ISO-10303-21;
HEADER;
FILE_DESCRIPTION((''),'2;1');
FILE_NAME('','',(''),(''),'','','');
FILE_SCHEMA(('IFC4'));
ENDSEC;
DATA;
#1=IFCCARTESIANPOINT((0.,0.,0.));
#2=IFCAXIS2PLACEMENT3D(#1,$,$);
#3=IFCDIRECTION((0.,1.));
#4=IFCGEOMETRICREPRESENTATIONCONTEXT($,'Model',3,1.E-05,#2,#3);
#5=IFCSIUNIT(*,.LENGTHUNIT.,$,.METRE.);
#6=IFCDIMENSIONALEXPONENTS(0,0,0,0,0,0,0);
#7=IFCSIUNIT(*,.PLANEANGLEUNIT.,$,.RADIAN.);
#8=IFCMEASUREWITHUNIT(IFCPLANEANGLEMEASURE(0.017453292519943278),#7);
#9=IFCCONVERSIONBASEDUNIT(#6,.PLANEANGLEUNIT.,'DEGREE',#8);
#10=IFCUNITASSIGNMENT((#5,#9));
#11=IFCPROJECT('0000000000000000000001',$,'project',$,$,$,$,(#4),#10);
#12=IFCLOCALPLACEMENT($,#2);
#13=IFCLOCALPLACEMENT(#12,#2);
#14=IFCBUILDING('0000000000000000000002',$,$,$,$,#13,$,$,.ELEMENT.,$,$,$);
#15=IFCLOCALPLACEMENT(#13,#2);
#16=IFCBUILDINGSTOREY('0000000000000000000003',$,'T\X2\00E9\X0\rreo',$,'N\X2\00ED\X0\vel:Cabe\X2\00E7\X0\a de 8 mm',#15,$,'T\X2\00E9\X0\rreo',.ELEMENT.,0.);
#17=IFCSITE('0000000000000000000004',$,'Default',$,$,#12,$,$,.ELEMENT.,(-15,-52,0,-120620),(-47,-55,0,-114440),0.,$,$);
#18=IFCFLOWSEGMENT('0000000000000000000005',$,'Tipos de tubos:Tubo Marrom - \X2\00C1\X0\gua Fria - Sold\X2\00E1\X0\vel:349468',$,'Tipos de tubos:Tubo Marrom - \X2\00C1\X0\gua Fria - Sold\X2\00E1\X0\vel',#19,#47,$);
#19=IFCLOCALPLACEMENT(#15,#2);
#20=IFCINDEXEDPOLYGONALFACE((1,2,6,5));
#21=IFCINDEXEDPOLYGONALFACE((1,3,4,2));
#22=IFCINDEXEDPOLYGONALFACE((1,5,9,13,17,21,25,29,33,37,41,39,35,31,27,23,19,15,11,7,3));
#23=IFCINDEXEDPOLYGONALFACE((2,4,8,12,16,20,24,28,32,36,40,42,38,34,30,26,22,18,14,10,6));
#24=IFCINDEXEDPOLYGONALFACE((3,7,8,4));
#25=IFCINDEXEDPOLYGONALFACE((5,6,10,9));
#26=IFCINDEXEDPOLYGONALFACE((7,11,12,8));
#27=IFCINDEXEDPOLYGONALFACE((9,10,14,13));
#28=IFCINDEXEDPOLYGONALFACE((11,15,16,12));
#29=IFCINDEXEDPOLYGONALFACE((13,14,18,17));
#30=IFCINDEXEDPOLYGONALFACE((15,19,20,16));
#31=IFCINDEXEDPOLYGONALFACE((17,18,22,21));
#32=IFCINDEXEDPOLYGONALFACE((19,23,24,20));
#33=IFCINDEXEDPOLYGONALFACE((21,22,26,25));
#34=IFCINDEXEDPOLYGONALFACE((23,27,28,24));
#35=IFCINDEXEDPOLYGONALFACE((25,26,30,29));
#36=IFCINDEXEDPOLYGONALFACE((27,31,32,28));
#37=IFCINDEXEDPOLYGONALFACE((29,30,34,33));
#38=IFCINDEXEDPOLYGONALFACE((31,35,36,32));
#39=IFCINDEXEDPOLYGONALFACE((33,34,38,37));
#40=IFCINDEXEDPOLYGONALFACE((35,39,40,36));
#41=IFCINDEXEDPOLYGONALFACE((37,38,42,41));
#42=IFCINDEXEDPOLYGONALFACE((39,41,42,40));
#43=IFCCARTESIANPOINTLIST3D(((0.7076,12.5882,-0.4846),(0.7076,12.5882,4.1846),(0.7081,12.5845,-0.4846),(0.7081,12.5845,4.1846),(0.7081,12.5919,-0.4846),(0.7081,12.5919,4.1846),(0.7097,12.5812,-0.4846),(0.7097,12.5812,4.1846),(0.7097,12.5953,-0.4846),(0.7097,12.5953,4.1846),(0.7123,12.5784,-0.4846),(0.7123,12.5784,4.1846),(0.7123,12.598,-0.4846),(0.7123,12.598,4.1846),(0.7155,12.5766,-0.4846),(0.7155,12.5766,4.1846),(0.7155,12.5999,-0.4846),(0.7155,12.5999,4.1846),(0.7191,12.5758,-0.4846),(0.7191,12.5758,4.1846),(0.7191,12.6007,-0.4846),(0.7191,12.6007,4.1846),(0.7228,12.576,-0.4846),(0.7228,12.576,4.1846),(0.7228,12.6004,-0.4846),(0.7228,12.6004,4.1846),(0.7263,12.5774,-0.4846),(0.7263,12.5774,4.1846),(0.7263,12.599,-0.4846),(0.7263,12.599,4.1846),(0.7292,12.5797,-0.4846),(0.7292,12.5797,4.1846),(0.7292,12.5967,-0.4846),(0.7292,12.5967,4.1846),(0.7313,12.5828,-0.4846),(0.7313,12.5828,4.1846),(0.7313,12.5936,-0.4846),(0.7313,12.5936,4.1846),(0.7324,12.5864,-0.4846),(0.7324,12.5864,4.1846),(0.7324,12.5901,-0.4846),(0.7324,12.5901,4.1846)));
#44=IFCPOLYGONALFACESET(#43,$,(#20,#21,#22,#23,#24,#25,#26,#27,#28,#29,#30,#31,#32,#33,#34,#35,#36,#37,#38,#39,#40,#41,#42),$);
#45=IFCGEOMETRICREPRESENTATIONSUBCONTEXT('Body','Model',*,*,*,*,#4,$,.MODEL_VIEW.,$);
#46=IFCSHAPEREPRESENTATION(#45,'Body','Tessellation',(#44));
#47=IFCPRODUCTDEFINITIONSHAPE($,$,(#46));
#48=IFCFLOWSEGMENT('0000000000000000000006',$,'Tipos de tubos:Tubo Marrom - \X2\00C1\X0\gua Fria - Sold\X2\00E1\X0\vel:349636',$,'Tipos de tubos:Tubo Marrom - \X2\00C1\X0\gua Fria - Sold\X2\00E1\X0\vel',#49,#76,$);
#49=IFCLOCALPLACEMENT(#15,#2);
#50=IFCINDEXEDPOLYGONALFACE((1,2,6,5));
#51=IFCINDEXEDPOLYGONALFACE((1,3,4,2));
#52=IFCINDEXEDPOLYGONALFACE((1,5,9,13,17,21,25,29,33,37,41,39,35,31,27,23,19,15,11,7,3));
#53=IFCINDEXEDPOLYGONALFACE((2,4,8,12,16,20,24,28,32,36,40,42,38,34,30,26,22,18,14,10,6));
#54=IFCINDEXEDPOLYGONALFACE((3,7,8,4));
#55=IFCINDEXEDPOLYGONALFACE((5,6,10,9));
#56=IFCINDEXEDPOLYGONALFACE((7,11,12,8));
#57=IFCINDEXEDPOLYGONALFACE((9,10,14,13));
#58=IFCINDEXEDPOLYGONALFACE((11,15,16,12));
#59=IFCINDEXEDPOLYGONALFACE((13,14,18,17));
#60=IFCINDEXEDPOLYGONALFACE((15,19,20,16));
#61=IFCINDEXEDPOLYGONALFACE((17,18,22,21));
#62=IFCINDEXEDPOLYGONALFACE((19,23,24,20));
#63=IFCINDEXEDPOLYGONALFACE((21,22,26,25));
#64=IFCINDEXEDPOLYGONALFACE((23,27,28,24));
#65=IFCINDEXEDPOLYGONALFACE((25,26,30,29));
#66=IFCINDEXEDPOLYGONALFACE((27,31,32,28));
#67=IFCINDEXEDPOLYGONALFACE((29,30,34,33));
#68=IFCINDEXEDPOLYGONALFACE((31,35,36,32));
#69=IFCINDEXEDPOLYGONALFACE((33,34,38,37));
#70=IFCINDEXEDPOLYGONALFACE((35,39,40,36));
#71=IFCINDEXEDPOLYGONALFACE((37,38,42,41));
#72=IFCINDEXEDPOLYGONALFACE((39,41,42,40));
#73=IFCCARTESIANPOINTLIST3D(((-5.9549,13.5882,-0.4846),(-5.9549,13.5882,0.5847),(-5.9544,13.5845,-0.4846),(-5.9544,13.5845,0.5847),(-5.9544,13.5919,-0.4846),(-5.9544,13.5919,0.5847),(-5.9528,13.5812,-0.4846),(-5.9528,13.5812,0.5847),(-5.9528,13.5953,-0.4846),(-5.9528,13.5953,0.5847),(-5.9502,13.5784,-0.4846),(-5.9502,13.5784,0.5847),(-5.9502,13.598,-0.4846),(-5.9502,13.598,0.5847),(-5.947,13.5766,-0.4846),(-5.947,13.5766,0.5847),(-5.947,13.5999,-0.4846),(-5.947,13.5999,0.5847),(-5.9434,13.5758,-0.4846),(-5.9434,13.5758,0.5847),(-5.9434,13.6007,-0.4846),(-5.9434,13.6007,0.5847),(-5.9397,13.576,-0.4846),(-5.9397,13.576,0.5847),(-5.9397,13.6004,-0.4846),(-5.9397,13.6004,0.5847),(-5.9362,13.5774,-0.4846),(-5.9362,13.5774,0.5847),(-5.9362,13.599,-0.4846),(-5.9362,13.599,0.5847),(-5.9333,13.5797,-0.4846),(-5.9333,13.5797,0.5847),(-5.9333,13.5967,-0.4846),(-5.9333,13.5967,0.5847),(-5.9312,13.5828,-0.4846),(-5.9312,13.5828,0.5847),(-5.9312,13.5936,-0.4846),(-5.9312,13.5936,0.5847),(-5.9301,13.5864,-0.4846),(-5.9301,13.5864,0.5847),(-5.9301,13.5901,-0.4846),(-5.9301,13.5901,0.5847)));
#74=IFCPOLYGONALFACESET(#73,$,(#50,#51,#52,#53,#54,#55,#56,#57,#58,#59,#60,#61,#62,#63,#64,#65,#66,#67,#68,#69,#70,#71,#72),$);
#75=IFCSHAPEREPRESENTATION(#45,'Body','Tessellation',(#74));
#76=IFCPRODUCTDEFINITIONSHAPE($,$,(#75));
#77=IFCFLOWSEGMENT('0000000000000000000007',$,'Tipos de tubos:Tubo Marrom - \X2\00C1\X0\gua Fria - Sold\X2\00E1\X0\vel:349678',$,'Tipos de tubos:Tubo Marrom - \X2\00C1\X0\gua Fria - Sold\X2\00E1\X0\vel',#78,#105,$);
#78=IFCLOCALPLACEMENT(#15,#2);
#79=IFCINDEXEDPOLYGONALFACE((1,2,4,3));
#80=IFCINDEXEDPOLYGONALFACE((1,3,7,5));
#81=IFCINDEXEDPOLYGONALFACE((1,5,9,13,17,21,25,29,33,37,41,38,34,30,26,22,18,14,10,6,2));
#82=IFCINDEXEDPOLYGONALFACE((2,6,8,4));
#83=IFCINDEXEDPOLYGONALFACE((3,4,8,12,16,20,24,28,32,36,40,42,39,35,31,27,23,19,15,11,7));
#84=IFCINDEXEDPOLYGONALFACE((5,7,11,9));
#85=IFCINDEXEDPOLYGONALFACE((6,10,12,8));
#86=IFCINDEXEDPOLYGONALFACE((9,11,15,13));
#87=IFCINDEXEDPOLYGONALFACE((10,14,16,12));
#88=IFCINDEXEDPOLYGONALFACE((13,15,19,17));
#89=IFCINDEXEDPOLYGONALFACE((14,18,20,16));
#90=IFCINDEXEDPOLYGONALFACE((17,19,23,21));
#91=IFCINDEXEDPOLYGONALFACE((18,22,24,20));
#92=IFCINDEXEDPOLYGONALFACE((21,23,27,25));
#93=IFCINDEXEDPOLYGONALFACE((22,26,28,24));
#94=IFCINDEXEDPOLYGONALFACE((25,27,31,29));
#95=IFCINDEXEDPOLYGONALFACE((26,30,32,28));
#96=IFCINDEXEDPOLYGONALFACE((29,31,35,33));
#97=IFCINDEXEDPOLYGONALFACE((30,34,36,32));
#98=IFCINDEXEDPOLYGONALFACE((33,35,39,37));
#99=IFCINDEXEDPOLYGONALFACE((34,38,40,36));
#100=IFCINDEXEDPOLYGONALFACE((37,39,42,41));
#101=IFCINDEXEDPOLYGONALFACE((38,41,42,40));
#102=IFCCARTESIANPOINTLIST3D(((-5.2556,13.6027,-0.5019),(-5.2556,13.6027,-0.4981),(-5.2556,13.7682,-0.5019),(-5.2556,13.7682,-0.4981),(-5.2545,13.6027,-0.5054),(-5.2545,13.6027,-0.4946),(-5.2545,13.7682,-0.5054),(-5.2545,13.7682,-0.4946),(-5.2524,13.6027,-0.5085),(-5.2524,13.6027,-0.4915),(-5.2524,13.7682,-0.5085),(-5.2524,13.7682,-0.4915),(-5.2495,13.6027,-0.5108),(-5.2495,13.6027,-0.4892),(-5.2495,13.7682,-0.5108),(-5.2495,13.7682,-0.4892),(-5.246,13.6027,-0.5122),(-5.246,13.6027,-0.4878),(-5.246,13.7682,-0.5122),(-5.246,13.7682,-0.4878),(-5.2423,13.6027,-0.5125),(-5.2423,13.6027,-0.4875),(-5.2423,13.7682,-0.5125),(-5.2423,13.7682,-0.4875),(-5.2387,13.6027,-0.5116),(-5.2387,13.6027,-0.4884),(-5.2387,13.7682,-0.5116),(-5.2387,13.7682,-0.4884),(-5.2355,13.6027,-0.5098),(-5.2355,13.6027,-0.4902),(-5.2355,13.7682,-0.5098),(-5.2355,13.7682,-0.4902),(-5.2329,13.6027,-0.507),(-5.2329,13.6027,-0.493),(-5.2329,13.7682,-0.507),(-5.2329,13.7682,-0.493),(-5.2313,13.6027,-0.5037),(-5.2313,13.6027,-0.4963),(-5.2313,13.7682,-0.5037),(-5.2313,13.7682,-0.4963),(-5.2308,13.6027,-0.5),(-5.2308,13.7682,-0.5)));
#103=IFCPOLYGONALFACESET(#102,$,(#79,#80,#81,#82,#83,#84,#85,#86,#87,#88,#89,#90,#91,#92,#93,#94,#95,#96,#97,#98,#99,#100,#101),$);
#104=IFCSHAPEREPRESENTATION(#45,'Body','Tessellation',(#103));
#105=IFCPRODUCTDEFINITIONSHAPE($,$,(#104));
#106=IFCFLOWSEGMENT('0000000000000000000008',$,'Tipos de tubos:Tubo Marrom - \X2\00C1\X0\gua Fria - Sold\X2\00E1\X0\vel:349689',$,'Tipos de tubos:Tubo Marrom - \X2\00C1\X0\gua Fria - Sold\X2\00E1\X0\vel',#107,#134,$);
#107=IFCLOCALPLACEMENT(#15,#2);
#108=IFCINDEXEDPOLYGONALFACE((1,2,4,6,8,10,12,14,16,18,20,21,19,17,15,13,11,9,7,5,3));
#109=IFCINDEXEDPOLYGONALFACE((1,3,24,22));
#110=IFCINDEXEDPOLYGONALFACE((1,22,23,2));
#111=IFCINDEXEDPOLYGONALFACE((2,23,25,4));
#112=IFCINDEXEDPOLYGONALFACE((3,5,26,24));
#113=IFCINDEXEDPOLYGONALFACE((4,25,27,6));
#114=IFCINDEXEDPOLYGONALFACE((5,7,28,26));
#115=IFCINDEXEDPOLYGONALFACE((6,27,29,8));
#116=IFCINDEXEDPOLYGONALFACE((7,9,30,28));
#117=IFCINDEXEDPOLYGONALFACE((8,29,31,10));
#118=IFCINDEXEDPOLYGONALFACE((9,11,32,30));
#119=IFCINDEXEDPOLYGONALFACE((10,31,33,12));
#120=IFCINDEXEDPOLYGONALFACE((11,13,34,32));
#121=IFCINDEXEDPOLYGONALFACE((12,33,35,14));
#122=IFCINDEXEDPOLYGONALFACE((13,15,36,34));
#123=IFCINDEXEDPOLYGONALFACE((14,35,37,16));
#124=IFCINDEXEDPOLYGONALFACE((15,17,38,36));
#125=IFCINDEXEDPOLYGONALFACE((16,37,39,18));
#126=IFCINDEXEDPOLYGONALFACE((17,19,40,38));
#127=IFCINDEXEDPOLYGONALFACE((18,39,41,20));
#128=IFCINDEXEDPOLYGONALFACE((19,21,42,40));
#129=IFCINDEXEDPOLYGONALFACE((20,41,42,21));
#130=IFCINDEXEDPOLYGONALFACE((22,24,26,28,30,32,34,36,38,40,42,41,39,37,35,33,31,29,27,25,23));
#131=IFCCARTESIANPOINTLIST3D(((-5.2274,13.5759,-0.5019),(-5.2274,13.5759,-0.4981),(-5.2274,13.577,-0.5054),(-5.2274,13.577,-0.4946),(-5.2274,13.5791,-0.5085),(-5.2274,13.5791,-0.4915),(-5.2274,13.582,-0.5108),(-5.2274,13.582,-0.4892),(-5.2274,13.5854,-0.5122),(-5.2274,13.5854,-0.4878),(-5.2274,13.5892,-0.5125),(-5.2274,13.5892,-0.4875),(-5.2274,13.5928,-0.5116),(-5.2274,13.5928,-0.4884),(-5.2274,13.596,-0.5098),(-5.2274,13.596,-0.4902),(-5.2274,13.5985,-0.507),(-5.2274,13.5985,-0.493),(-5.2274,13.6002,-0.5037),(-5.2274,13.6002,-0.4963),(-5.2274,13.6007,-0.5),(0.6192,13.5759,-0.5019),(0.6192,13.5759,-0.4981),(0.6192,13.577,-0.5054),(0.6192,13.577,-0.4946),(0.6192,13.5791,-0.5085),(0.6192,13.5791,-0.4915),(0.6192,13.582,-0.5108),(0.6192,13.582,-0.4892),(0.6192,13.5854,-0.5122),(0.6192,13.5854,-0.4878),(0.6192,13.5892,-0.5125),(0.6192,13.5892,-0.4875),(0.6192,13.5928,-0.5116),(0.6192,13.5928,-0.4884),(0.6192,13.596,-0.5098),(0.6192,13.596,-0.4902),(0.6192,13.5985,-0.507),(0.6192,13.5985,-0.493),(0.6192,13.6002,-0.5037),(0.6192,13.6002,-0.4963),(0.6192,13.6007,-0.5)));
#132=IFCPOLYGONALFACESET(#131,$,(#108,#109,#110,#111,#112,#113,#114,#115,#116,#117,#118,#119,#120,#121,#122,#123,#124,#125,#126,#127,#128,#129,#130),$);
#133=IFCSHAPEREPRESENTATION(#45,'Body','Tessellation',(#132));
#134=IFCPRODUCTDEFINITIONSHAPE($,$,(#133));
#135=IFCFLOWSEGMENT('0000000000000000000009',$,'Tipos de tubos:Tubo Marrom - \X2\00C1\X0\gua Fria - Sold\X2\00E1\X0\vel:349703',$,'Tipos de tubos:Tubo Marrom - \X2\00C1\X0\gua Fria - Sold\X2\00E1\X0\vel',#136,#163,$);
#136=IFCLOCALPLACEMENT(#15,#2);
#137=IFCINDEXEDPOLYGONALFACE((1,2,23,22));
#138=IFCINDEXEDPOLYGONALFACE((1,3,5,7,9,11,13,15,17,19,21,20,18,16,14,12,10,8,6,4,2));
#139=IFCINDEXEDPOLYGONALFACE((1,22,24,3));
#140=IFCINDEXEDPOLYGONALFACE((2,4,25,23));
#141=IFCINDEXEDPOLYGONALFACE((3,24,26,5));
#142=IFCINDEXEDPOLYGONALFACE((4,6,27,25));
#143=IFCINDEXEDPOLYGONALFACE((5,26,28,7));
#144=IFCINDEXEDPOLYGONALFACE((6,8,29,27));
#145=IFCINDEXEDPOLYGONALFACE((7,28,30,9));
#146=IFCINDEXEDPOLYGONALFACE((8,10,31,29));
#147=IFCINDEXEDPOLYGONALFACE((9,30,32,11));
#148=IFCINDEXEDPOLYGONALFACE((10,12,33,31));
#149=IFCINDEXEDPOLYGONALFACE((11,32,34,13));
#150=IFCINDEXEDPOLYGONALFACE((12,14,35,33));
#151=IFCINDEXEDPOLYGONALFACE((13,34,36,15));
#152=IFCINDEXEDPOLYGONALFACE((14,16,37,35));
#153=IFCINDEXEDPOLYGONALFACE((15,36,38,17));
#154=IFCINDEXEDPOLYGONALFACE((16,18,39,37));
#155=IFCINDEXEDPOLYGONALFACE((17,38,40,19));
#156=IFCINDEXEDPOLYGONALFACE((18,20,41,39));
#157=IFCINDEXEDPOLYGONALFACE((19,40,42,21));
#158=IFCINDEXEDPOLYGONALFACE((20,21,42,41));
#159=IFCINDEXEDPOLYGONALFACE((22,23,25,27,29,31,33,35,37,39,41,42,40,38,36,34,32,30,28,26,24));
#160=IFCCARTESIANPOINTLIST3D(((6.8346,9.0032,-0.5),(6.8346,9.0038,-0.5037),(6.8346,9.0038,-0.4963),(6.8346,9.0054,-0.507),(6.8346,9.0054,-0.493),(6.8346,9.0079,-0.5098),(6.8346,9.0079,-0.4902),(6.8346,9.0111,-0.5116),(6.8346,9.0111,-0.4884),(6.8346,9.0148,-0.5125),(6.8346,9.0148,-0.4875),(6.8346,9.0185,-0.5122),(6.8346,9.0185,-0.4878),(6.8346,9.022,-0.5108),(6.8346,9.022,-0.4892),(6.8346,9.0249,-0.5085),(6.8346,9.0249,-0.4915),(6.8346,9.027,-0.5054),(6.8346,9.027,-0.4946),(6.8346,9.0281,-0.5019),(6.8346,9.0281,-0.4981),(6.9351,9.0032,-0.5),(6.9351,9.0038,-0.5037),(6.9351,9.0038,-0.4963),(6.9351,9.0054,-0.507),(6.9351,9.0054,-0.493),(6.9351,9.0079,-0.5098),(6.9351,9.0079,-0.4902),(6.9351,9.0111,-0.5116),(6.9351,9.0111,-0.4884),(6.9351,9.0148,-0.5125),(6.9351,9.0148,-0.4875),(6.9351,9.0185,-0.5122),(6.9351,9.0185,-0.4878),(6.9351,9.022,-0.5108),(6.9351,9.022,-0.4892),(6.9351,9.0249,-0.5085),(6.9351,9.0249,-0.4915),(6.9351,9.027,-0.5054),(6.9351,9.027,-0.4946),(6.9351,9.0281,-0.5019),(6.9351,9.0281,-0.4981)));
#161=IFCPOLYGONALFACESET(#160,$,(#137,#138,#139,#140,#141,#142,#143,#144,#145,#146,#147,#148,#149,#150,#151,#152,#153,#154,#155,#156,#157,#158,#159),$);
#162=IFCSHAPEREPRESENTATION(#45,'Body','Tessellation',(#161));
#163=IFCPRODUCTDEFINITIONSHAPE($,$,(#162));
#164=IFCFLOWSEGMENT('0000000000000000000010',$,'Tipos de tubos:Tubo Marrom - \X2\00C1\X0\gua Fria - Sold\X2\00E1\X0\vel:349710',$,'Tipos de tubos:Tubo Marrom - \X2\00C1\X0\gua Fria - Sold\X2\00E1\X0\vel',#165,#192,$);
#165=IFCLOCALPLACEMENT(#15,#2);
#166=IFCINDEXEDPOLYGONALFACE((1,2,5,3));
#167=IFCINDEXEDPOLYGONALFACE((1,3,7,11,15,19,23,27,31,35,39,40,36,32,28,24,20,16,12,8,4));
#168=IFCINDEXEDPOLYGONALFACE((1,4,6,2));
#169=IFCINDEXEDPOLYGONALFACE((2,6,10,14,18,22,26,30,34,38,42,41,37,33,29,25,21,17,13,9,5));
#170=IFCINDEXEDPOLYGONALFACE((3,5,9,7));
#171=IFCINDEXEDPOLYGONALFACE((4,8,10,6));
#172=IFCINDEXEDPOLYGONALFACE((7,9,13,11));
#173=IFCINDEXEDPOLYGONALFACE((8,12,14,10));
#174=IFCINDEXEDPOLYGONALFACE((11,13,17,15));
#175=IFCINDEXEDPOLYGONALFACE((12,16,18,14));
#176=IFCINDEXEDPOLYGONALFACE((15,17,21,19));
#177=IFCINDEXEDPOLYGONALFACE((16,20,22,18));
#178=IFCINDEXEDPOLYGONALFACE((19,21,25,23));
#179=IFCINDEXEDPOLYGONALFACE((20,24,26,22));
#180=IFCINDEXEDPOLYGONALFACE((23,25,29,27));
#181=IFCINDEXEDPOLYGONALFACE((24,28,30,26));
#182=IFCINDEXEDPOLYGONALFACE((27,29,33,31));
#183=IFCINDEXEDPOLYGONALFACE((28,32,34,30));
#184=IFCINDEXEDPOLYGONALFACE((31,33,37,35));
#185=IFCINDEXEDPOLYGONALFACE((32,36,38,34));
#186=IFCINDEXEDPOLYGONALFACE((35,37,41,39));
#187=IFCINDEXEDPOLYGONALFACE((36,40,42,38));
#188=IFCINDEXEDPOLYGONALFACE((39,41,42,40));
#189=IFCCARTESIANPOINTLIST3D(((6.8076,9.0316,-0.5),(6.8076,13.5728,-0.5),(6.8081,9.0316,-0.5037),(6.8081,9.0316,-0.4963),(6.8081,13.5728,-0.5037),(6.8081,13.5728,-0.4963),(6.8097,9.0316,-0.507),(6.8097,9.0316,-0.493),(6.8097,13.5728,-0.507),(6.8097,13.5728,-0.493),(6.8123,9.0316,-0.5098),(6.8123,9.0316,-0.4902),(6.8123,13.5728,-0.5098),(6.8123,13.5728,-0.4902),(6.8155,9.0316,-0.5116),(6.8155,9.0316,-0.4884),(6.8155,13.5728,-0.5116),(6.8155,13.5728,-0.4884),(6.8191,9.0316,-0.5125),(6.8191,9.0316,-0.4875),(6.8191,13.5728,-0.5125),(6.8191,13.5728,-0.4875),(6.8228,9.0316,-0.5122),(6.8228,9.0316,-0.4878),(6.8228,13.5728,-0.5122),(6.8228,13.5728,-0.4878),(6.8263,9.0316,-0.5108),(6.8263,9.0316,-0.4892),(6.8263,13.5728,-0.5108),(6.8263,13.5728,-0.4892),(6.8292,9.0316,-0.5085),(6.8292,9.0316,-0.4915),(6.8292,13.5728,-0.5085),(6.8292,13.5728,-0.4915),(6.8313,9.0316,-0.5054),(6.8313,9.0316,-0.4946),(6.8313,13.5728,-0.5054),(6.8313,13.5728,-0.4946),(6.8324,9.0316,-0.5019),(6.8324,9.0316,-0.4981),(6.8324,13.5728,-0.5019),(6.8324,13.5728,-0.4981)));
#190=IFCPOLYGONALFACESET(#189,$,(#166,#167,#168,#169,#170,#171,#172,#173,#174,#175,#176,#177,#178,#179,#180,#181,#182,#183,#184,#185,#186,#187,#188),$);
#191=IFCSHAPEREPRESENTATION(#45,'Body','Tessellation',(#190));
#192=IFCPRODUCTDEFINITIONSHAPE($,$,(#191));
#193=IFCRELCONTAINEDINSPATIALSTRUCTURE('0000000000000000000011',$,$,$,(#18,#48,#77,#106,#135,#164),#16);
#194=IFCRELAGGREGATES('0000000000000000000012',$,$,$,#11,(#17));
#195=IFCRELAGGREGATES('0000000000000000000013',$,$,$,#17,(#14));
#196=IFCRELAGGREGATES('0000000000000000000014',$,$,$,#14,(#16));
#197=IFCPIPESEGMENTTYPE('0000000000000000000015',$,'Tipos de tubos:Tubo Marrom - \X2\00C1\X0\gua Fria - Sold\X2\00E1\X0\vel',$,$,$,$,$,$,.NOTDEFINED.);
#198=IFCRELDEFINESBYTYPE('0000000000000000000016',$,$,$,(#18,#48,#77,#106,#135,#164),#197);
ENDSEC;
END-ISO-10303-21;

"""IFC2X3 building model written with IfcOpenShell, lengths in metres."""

from ifc_helpers import new_model, entity, si_unit, converted_unit, direction, frame, frame_2d, origin, origin_2d_with_axis, place, context, subcontext, project, spatial, circle, extrude, type_object, element, save


model = new_model("IFC2X3")

# Units and contexts
model_context = context("Model", 3, precision=1e-05, world=origin(), true_north=direction((0.0, 1.0)))
body_context = subcontext(model_context, "Body", "Model", "MODEL_VIEW")
ifc_project = project(units=[si_unit("LENGTHUNIT", "METRE"), converted_unit("PLANEANGLEUNIT", "DEGREE", entity("IfcPlaneAngleMeasure", 0.017453292519943278), si_unit("PLANEANGLEUNIT", "RADIAN"), dimensions=[0, 0, 0, 0, 0, 0, 0])], contexts=[model_context])

# Site, building, storey
site_placement = place(None, origin())
site = spatial("IfcSite", under=ifc_project, at=site_placement, Name="Default", CompositionType="ELEMENT", RefLatitude=(-15, -52, 0, -120620), RefLongitude=(-47, -55, 0, -114440), RefElevation=0.0)
building_placement = place(site_placement, origin())
building = spatial("IfcBuilding", under=site, at=building_placement, CompositionType="ELEMENT")
storey_placement = place(building_placement, origin())
storey = spatial("IfcBuildingStorey", under=building, at=storey_placement, Name="Térreo", ObjectType="Nível:Cabeça de 8 mm", LongName="Térreo", CompositionType="ELEMENT", Elevation=0.0)

# Flow segments
pipe_segment_type = type_object("IfcPipeSegmentType", Name="Tipos de tubos:Tubo Marrom - Água Fria - Soldável", PredefinedType="NOTDEFINED")
flow_segment_1_placement = place(storey_placement, origin())
element("IfcFlowSegment", 1, at=flow_segment_1_placement, inside=storey, type_object=pipe_segment_type, Name="Tipos de tubos:Tubo Marrom - Água Fria - Soldável:349468", ObjectType="Tipos de tubos:Tubo Marrom - Água Fria - Soldável", context=body_context, shape_type="SweptSolid", body=[
    extrude(circle(Radius=0.0125, at=frame_2d((0.0, 0.0), x_axis=(1.0, 0.0))), frame((0.7201, 12.5882, -0.4846), z_axis=(0.0, 0.0, 1.0), x_axis=(-1.0, 0.0, 0.0)), (0.0, 0.0, 1.0), 4.6692),
])
flow_segment_2_placement = place(storey_placement, origin())
element("IfcFlowSegment", 2, at=flow_segment_2_placement, inside=storey, type_object=pipe_segment_type, Name="Tipos de tubos:Tubo Marrom - Água Fria - Soldável:349636", ObjectType="Tipos de tubos:Tubo Marrom - Água Fria - Soldável", context=body_context, shape_type="SweptSolid", body=[
    extrude(circle(Radius=0.0125, at=origin_2d_with_axis()), frame((-5.9424, 13.5882, -0.4846), z_axis=(0.0, 0.0, 1.0), x_axis=(-1.0, 0.0, 0.0)), (0.0, 0.0, 1.0), 1.0693),
])
flow_segment_3_placement = place(storey_placement, origin())
element("IfcFlowSegment", 3, at=flow_segment_3_placement, inside=storey, type_object=pipe_segment_type, Name="Tipos de tubos:Tubo Marrom - Água Fria - Soldável:349678", ObjectType="Tipos de tubos:Tubo Marrom - Água Fria - Soldável", context=body_context, shape_type="SweptSolid", body=[
    extrude(circle(Radius=0.0125, at=origin_2d_with_axis()), frame((-5.2433, 13.6027, -0.5), z_axis=(0.0, 1.0, 0.0), x_axis=(1.0, 0.0, 0.0)), (0.0, 0.0, 1.0), 0.1655),
])
flow_segment_4_placement = place(storey_placement, origin())
element("IfcFlowSegment", 4, at=flow_segment_4_placement, inside=storey, type_object=pipe_segment_type, Name="Tipos de tubos:Tubo Marrom - Água Fria - Soldável:349689", ObjectType="Tipos de tubos:Tubo Marrom - Água Fria - Soldável", context=body_context, shape_type="SweptSolid", body=[
    extrude(circle(Radius=0.0125, at=frame_2d((0.0, 0.0), x_axis=(1.0, 0.0))), frame((-5.2274, 13.5882, -0.5), z_axis=(1.0, 0.0, 0.0), x_axis=(0.0, 1.0, 0.0)), (0.0, 0.0, 1.0), 5.8466),
])
flow_segment_5_placement = place(storey_placement, origin())
element("IfcFlowSegment", 5, at=flow_segment_5_placement, inside=storey, type_object=pipe_segment_type, Name="Tipos de tubos:Tubo Marrom - Água Fria - Soldável:349703", ObjectType="Tipos de tubos:Tubo Marrom - Água Fria - Soldável", context=body_context, shape_type="SweptSolid", body=[
    extrude(circle(Radius=0.0125, at=origin_2d_with_axis()), frame((6.8346, 9.0157, -0.5), z_axis=(1.0, 0.0, 0.0), x_axis=(0.0, -1.0, 0.0)), (0.0, 0.0, 1.0), 0.1005),
])
flow_segment_6_placement = place(storey_placement, origin())
element("IfcFlowSegment", 6, at=flow_segment_6_placement, inside=storey, type_object=pipe_segment_type, Name="Tipos de tubos:Tubo Marrom - Água Fria - Soldável:349710", ObjectType="Tipos de tubos:Tubo Marrom - Água Fria - Soldável", context=body_context, shape_type="SweptSolid", body=[
    extrude(circle(Radius=0.0125, at=frame_2d((0.0, 0.0), x_axis=(1.0, 0.0))), frame((6.8201, 9.0316, -0.5), z_axis=(0.0, 1.0, 0.0), x_axis=(-1.0, 0.0, 0.0)), (0.0, 0.0, 1.0), 4.5412),
])

save(model, "model.ifc")
